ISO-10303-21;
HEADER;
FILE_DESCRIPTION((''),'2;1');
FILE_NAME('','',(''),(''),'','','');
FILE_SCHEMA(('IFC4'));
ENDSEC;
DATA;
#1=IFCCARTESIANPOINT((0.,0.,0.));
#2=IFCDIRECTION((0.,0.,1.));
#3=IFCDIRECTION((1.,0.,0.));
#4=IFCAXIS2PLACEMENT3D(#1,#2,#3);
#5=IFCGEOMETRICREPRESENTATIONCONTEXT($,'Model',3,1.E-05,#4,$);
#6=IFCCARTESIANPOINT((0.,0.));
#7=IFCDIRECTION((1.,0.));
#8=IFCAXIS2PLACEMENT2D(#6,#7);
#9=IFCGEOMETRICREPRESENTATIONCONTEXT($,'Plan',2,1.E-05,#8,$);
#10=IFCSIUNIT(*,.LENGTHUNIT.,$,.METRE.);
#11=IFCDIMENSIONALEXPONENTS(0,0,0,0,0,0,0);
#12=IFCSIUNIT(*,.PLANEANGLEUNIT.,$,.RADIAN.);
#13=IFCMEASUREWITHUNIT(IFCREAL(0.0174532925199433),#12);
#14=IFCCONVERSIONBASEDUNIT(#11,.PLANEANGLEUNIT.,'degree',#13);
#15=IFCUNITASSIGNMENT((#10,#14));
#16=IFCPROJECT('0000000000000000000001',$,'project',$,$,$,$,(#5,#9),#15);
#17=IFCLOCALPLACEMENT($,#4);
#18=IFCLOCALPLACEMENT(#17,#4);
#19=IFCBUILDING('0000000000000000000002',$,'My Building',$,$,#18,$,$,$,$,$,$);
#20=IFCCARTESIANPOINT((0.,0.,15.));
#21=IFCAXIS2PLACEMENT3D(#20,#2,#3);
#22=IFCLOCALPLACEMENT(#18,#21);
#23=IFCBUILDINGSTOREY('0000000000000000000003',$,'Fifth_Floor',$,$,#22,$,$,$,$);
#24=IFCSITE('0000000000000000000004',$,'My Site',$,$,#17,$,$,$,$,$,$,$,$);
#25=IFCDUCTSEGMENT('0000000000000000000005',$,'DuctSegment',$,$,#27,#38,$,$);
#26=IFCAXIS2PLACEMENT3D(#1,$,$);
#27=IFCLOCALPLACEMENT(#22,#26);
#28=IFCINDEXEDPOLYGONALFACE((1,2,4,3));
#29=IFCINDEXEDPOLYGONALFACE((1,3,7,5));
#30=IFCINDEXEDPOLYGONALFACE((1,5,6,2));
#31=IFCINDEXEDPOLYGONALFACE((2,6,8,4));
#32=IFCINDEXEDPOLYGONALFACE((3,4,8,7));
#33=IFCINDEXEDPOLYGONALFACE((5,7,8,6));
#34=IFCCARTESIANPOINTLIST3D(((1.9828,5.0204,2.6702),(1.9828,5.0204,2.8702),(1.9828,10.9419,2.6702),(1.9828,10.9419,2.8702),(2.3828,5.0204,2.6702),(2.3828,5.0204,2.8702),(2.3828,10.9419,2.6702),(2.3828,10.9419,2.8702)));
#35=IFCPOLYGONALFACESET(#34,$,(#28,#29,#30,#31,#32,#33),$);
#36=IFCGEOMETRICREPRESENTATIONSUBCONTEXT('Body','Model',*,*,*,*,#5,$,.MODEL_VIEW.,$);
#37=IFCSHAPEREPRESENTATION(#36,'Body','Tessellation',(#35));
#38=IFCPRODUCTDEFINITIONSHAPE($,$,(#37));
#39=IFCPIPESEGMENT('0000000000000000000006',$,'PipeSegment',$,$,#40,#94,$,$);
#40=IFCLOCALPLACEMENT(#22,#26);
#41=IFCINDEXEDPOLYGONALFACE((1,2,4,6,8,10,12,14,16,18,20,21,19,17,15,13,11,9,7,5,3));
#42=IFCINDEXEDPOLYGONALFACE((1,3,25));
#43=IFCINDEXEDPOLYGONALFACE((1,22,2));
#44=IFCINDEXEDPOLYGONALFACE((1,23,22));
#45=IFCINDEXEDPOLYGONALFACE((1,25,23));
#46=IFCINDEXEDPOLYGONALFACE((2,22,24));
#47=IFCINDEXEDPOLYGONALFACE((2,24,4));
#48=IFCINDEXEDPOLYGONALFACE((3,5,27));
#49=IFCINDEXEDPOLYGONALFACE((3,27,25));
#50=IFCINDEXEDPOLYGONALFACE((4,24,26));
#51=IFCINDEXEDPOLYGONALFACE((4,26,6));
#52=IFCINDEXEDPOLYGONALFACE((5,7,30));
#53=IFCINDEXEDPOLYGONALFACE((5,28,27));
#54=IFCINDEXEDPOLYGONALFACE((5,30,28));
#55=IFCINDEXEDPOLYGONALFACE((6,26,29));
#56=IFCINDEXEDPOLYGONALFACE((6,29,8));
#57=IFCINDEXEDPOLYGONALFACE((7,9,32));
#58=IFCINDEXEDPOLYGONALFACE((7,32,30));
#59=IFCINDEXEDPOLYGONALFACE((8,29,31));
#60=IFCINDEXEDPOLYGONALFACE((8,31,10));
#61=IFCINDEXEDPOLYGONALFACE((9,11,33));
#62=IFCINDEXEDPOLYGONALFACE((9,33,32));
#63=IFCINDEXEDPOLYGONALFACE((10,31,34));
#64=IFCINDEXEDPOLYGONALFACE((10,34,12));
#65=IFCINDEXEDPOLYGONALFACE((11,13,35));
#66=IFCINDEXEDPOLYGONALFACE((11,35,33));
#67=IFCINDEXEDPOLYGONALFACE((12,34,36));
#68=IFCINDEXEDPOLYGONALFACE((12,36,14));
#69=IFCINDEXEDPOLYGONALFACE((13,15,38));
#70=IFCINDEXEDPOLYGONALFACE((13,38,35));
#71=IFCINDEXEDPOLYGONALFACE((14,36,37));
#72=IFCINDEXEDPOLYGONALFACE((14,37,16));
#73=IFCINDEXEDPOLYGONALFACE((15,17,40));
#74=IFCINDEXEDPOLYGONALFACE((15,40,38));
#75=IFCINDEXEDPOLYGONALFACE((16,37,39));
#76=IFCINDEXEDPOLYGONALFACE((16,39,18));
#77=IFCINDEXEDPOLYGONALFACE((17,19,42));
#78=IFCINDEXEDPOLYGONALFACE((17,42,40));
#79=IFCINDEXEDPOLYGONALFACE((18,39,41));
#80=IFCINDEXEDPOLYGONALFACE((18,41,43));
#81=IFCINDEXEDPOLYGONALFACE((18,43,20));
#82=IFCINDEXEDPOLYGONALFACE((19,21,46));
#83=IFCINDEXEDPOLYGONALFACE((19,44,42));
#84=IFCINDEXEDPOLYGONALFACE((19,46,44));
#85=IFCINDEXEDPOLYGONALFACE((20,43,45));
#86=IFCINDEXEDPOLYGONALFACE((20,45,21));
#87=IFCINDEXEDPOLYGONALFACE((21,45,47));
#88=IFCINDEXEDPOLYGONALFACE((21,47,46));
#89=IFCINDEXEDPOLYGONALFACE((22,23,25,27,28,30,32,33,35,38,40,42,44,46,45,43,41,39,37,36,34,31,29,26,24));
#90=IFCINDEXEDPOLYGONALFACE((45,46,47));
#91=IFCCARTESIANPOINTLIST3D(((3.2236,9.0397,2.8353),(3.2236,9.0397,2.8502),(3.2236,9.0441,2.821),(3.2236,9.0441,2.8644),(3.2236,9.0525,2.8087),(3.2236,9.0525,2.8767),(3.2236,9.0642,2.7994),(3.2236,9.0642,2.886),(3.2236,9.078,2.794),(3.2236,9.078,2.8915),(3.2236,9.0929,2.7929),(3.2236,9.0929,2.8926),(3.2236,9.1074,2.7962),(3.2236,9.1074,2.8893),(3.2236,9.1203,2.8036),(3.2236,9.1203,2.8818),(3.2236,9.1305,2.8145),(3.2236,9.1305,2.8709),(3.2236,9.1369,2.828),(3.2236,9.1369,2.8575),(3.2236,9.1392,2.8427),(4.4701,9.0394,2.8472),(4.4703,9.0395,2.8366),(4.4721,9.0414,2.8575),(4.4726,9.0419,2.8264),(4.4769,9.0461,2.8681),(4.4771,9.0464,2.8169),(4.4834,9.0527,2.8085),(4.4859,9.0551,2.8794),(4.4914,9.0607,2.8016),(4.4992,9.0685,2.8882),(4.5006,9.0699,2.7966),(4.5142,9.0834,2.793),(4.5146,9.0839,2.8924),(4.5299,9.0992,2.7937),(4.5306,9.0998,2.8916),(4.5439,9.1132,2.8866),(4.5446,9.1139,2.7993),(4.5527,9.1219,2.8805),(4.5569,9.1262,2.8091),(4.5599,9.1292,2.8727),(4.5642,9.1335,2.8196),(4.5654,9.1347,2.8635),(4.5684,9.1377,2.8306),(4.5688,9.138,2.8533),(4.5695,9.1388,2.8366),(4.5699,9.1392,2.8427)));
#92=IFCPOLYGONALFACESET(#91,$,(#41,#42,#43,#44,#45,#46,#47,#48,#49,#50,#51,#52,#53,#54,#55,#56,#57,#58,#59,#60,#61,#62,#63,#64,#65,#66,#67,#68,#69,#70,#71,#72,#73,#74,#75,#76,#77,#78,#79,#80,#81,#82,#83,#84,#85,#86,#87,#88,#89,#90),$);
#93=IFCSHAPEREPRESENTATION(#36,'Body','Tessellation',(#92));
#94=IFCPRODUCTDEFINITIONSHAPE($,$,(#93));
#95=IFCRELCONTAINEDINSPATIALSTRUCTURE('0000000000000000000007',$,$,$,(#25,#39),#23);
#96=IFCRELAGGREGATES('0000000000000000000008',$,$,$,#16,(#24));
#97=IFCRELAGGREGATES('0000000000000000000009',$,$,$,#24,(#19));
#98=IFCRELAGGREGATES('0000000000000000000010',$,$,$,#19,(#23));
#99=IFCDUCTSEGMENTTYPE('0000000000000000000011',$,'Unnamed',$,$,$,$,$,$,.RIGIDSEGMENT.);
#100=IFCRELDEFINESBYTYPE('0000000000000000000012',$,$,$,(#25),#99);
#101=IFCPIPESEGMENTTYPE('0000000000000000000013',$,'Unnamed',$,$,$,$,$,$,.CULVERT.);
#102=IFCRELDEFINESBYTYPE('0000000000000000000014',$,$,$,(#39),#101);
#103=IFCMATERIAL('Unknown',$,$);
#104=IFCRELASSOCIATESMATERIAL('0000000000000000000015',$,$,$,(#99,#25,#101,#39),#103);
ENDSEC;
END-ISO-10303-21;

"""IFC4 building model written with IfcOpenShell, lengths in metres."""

from ifc_helpers import new_model, entity, si_unit, converted_unit, frame, origin_with_axes, origin_2d_with_axis, place, context, subcontext, project, spatial, rectangle, circle, extrude, clip, halfspace, material, material_profile, profile_set, profile_usage, type_object, element, save


model = new_model("IFC4")

# Units and contexts
model_context = context("Model", 3, precision=1e-05, world=origin_with_axes())
plan_context = context("Plan", 2, precision=1e-05, world=origin_2d_with_axis())
body_context_1 = subcontext(model_context, "Body", "Model", "MODEL_VIEW")
ifc_project = project(units=[si_unit("LENGTHUNIT", "METRE"), converted_unit("PLANEANGLEUNIT", "degree", entity("IfcReal", 0.0174532925199433), si_unit("PLANEANGLEUNIT", "RADIAN"), dimensions=[0, 0, 0, 0, 0, 0, 0])], contexts=[model_context, plan_context])

# Site, building, storey
site_placement = place(None, origin_with_axes())
site = spatial("IfcSite", under=ifc_project, at=site_placement, Name="My Site")
building_placement = place(site_placement, origin_with_axes())
building = spatial("IfcBuilding", under=site, at=building_placement, Name="My Building")
storey_placement = place(building_placement, frame((0.0, 0.0, 15.0), z_axis=(0.0, 0.0, 1.0), x_axis=(1.0, 0.0, 0.0)))
storey = spatial("IfcBuildingStorey", under=building, at=storey_placement, Name="Fifth_Floor")

# Shared definitions
ifc_material = material(Name="Unknown")

# Duct segment
ifc_material_profile_1 = material_profile(ifc_material, rectangle(XDim=0.4, YDim=0.2))
ifc_profile_set_1 = profile_set([ifc_material_profile_1])
duct_segment_type = type_object("IfcDuctSegmentType", Name="Unnamed", PredefinedType="RIGIDSEGMENT", material=ifc_profile_set_1)
ifc_profile_usage_1 = profile_usage(ifc_profile_set_1, cardinal=5)
duct_segment_1_placement = place(storey_placement, frame((2.1828, 10.9419, 2.7702), z_axis=(0.0, -1.0, 0.0), x_axis=(1.0, 0.0, 0.0)))
element("IfcDuctSegment", 1, at=duct_segment_1_placement, inside=storey, type_object=duct_segment_type, material=ifc_profile_usage_1, Name="DuctSegment", context=body_context_1, shape_type="SweptSolid", body=[
    extrude(rectangle(XDim=0.4, YDim=0.2), origin_with_axes(), (0.0, 0.0, 1.0), 5.9215),
])

# Pipe segment
ifc_material_profile_2 = material_profile(ifc_material, circle(Radius=0.05))
ifc_profile_set_2 = profile_set([ifc_material_profile_2])
pipe_segment_type = type_object("IfcPipeSegmentType", Name="Unnamed", PredefinedType="CULVERT", material=ifc_profile_set_2)
ifc_profile_usage_2 = profile_usage(ifc_profile_set_2, cardinal=5)
pipe_segment_1_placement = place(storey_placement, frame((3.2236, 9.0892, 2.8427), z_axis=(1.0, -0.000001, 0.000001), x_axis=(0.000001, 1.0, 0.0)))
element("IfcPipeSegment", 2, at=pipe_segment_1_placement, inside=storey, type_object=pipe_segment_type, material=ifc_profile_usage_2, Name="PipeSegment", context=body_context_1, shape_type="Clipping", body=[
    clip(extrude(circle(Radius=0.05), origin_with_axes(), (0.0, 0.0, 1.0), 1.3463), halfspace(frame((0.05, -3.0, 1.3463), z_axis=(-0.707106, -0.000001, 0.707107), x_axis=(-0.000001, 1.0, 0.0)), False)),
])

save(model, "model.ifc")
